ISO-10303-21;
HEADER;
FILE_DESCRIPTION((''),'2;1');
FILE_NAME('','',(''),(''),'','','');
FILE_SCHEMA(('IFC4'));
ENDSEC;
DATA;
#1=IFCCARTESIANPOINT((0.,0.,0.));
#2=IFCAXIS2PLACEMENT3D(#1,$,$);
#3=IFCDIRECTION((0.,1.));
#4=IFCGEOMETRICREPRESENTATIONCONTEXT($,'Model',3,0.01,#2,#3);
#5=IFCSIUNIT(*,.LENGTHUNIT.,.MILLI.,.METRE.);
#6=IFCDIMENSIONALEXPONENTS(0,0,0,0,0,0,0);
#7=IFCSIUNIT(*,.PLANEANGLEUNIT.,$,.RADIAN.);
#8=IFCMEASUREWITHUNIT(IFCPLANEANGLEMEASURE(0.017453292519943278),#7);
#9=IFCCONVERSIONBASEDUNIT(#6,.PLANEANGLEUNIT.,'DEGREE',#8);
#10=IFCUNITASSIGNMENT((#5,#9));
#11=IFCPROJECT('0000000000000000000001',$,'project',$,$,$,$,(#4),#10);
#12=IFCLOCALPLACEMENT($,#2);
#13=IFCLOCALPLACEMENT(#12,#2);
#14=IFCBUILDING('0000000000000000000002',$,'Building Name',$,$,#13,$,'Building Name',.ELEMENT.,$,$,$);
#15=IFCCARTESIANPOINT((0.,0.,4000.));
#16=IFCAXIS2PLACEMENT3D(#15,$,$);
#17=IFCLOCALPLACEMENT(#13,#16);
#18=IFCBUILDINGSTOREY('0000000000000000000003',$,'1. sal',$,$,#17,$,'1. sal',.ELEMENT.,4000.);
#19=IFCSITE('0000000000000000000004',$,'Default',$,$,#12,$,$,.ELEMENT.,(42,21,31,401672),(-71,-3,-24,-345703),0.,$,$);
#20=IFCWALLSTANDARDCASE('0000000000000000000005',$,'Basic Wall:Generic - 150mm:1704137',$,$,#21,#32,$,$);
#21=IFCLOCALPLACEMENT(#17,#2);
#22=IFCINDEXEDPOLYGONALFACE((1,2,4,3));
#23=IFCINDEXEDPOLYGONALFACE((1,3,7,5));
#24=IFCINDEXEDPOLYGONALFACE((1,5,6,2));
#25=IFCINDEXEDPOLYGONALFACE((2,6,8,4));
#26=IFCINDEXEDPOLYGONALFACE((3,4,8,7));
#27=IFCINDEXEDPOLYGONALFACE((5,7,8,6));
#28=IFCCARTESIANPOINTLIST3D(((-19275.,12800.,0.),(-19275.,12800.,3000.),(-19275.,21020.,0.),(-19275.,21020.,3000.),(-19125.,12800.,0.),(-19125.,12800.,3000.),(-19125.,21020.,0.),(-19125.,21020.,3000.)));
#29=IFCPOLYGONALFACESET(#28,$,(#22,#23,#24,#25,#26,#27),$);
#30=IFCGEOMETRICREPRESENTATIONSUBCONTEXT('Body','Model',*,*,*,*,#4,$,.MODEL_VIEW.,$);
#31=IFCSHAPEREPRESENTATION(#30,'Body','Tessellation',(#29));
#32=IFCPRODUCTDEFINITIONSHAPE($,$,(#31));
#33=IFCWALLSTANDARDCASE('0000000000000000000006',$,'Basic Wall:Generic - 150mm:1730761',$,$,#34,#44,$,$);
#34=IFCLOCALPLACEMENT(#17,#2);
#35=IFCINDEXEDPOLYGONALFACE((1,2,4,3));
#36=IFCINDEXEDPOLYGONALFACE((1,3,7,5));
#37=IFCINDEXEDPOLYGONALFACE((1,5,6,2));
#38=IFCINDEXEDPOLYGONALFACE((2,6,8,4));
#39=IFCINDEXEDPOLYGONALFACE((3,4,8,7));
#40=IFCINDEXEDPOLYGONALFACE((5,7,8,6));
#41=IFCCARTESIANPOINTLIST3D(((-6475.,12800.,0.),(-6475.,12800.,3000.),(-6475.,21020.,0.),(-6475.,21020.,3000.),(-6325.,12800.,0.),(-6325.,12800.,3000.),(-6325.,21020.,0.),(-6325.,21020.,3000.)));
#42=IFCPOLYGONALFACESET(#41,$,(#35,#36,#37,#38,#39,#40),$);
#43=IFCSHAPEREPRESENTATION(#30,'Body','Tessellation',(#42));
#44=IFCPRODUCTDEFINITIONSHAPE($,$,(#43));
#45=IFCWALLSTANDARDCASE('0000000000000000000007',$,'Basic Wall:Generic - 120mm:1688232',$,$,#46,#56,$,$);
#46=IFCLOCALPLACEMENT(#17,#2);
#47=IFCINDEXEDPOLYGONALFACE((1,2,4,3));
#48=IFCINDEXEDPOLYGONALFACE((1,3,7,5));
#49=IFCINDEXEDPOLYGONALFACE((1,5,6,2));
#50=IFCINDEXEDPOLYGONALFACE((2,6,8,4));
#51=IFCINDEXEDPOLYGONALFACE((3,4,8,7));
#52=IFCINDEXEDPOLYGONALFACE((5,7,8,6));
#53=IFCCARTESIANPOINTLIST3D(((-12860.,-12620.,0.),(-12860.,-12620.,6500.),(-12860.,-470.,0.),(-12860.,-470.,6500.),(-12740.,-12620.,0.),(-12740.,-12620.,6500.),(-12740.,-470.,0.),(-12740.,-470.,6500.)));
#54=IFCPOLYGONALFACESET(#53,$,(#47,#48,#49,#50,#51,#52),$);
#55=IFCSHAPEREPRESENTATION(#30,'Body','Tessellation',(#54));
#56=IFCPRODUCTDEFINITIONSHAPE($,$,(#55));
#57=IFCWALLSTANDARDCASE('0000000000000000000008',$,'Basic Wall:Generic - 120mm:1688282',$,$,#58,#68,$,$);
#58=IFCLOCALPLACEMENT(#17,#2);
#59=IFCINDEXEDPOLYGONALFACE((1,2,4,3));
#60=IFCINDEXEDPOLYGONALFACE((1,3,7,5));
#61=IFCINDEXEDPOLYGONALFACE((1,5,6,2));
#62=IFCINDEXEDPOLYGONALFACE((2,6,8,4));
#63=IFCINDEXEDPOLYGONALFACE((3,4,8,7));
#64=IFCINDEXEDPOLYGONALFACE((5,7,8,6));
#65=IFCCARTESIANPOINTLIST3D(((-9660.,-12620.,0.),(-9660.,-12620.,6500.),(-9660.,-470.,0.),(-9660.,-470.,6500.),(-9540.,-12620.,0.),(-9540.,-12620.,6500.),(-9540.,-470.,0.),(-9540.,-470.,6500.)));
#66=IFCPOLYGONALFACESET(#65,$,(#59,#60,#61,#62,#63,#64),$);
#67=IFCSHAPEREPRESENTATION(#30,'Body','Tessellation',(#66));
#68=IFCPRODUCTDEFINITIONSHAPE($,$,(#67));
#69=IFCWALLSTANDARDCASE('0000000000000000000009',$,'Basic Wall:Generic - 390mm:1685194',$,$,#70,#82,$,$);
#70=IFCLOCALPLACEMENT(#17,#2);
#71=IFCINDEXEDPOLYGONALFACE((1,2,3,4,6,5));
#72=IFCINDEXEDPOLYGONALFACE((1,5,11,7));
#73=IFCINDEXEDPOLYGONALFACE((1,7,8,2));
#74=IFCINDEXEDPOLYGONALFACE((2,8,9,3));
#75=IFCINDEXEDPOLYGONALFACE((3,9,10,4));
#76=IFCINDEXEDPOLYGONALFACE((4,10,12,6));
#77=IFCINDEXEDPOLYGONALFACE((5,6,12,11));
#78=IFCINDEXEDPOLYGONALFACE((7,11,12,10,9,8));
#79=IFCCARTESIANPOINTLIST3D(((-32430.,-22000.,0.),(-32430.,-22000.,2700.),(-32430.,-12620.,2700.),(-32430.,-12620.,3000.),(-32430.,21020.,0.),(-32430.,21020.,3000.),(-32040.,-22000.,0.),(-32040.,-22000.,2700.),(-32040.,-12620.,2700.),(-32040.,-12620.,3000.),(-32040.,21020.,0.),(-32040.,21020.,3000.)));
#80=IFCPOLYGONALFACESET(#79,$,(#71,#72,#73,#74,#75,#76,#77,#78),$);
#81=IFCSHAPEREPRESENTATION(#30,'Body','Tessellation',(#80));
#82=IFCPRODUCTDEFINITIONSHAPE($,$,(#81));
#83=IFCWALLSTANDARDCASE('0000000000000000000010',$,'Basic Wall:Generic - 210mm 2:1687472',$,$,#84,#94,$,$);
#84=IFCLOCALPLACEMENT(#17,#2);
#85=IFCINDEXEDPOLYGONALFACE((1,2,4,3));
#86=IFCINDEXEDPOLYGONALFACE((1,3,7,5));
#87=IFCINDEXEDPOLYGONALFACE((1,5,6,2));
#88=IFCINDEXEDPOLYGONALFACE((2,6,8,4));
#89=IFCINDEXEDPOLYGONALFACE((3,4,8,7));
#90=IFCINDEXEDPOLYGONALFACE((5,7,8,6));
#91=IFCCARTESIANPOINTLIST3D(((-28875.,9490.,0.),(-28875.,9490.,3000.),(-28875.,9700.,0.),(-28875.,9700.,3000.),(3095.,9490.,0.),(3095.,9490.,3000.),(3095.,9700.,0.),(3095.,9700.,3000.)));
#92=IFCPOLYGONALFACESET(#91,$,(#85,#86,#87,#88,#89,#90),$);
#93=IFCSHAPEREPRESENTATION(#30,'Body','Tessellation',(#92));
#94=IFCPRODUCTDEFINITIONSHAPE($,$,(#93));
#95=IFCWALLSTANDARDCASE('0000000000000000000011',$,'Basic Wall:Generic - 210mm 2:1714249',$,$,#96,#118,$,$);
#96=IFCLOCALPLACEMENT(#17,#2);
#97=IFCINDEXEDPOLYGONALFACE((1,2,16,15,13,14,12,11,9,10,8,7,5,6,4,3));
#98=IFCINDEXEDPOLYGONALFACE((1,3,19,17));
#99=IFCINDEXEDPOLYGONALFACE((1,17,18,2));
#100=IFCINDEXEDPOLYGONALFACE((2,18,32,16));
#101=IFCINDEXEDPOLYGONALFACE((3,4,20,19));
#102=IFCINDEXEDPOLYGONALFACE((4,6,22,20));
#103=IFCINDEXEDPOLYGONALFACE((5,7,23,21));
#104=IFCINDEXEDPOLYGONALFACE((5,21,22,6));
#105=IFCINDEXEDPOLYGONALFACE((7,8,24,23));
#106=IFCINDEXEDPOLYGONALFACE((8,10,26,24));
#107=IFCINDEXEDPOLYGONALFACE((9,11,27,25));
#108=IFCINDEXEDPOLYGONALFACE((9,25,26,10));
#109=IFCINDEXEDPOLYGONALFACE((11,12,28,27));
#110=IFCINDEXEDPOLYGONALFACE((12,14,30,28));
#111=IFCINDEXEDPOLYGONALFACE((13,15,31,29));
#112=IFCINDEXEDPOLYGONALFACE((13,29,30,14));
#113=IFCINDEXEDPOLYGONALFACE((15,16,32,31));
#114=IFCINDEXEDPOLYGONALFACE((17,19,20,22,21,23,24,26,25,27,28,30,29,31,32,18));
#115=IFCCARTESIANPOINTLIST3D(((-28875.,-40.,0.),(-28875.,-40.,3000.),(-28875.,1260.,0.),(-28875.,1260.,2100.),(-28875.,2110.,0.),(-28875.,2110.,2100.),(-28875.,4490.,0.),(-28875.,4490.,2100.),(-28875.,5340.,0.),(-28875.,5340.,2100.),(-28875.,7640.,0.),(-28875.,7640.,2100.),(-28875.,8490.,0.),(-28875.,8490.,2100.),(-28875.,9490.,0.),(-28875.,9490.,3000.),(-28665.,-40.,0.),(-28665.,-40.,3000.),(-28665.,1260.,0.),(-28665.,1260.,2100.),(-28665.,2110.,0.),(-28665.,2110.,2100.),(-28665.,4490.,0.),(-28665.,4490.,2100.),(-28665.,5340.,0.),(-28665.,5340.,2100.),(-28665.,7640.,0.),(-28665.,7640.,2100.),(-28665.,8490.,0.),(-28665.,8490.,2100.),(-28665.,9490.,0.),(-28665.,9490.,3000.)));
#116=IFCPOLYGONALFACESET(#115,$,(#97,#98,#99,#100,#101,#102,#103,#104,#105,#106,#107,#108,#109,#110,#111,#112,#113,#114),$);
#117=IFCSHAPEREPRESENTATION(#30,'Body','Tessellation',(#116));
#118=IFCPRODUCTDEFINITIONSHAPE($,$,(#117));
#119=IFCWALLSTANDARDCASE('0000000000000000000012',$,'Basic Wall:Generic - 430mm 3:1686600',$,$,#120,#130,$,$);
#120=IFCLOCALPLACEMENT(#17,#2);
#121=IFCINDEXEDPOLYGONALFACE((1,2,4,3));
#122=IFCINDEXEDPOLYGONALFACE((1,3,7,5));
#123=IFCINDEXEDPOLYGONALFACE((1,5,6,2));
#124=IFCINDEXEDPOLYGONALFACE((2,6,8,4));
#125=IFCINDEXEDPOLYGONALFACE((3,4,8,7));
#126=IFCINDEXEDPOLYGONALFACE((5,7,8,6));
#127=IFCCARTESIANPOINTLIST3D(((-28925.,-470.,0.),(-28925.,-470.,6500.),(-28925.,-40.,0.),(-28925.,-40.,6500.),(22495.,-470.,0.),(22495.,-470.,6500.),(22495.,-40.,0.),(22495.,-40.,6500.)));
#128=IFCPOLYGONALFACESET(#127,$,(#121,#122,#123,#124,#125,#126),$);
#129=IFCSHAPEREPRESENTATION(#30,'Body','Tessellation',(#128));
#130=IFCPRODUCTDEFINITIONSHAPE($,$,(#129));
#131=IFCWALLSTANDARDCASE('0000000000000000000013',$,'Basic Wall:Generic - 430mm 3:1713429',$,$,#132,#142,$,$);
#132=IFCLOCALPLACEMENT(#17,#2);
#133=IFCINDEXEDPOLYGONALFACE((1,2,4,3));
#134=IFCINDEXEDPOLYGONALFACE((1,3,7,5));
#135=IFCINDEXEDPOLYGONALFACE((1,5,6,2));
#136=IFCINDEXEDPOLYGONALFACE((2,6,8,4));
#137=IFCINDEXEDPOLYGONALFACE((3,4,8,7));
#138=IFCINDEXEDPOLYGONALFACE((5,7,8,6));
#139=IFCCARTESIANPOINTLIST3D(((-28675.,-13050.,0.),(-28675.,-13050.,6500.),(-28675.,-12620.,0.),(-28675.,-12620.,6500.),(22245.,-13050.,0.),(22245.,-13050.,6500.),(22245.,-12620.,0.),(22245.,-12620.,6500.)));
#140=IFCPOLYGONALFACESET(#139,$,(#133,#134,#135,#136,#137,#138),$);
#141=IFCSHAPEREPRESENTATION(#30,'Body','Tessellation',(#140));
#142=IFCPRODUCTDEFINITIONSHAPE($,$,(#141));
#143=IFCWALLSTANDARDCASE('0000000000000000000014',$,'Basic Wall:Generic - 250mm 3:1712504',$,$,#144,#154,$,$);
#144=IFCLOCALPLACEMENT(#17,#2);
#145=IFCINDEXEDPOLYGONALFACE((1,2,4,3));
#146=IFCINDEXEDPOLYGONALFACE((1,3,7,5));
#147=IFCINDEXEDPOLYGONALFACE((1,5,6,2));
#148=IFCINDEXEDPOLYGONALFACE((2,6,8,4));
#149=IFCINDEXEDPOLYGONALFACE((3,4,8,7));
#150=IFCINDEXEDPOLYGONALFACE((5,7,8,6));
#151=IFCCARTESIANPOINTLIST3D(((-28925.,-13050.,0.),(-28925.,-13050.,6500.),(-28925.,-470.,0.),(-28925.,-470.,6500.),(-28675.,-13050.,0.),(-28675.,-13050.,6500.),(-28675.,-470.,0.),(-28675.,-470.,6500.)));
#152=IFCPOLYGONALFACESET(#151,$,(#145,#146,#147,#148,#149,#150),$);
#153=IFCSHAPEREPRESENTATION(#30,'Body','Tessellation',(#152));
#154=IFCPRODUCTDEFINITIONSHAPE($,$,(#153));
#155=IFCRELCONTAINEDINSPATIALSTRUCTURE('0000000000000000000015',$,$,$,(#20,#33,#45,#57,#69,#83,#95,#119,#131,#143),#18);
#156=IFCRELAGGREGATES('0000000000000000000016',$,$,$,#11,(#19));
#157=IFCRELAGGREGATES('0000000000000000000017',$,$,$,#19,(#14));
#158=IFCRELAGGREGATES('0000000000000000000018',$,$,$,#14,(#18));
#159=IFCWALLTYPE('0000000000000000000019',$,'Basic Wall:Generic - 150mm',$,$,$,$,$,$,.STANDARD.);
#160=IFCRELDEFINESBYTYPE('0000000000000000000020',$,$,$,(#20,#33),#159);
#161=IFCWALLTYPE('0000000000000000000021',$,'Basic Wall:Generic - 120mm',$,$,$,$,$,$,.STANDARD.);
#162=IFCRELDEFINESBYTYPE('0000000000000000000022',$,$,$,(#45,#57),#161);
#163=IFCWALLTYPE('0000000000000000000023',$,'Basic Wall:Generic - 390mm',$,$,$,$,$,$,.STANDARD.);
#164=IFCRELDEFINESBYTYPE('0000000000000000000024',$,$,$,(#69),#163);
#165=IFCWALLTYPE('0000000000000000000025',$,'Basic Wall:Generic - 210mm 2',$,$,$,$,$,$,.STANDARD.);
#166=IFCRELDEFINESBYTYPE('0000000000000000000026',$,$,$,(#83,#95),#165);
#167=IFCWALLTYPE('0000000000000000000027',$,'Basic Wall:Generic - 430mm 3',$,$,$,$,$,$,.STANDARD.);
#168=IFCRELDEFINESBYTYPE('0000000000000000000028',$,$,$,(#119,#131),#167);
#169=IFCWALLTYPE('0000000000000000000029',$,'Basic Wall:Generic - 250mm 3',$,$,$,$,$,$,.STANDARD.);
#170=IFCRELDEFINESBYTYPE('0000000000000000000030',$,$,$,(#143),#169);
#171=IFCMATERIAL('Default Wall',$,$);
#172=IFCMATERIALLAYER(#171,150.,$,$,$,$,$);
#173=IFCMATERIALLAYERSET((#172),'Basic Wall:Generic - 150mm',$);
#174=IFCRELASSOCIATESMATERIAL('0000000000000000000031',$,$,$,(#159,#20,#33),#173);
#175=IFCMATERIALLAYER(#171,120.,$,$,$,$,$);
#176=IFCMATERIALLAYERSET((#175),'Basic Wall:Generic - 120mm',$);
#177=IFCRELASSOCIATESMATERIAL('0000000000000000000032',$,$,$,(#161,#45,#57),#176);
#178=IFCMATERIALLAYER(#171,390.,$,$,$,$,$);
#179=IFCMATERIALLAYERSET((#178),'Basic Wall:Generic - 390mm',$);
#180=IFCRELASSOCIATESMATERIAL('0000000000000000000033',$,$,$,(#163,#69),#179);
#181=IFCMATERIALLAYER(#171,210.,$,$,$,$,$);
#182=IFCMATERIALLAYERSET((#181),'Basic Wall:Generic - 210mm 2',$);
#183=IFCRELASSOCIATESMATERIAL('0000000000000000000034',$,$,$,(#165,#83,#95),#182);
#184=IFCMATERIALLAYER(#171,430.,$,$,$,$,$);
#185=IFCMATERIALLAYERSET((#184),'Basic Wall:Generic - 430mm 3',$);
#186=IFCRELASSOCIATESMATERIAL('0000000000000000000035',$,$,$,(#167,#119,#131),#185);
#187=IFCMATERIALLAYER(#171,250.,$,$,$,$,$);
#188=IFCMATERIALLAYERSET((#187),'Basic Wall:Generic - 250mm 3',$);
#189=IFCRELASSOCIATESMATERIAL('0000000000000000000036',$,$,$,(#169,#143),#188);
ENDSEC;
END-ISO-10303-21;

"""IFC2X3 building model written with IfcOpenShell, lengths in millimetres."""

from ifc_helpers import new_model, entity, si_unit, converted_unit, direction, frame, frame_2d, origin, place, context, subcontext, project, spatial, polyline, rectangle, extrude, clip, bounded_halfspace, material, layer, layer_set, layer_usage, type_object, element, save


model = new_model("IFC2X3")

# Units and contexts
model_context = context("Model", 3, precision=0.01, world=origin(), true_north=direction((0.0, 1.0)))
body_context = subcontext(model_context, "Body", "Model", "MODEL_VIEW")
ifc_project = project(units=[si_unit("LENGTHUNIT", "METRE", prefix="MILLI"), converted_unit("PLANEANGLEUNIT", "DEGREE", entity("IfcPlaneAngleMeasure", 0.017453292519943278), si_unit("PLANEANGLEUNIT", "RADIAN"), dimensions=[0, 0, 0, 0, 0, 0, 0])], contexts=[model_context])

# Site, building, storey
site_placement = place(None, origin())
site = spatial("IfcSite", under=ifc_project, at=site_placement, Name="Default", CompositionType="ELEMENT", RefLatitude=(42, 21, 31, 401672), RefLongitude=(-71, -3, -24, -345703), RefElevation=0.0)
building_placement = place(site_placement, origin())
building = spatial("IfcBuilding", under=site, at=building_placement, Name="Building Name", LongName="Building Name", CompositionType="ELEMENT")
storey_placement = place(building_placement, frame((0.0, 0.0, 4000.0)))
storey = spatial("IfcBuildingStorey", under=building, at=storey_placement, Name="1. sal", LongName="1. sal", CompositionType="ELEMENT", Elevation=4000.0)

# Walls
ifc_material_1 = material(Name="Default Wall")
ifc_layer_1 = layer(ifc_material_1, 150.0)
ifc_layer_set_1 = layer_set([ifc_layer_1], Name="Basic Wall:Generic - 150mm")
ifc_layer_usage_1 = layer_usage(ifc_layer_set_1, "AXIS2", "NEGATIVE", 75.0)
wall_type_1 = type_object("IfcWallType", Name="Basic Wall:Generic - 150mm", PredefinedType="STANDARD", material=ifc_layer_set_1)
wall_1_placement = place(storey_placement, frame((-19200.0, 21020.0, 0.0), z_axis=(0.0, 0.0, 1.0), x_axis=(0.0, -1.0, 0.0)))
element("IfcWallStandardCase", 1, at=wall_1_placement, inside=storey, type_object=wall_type_1, material=ifc_layer_usage_1, Name="Basic Wall:Generic - 150mm:1704137", context=body_context, shape_type="SweptSolid", body=[
    extrude(rectangle(XDim=8220.0, YDim=150.0, at=frame_2d((4110.0, 0.0), x_axis=(-1.0, 0.0))), origin(), (0.0, 0.0, 1.0), 3000.0),
])
ifc_layer_usage_2 = layer_usage(ifc_layer_set_1, "AXIS2", "NEGATIVE", 75.0)
wall_2_placement = place(storey_placement, frame((-6400.0, 21020.0, 0.0), z_axis=(0.0, 0.0, 1.0), x_axis=(0.0, -1.0, 0.0)))
element("IfcWallStandardCase", 2, at=wall_2_placement, inside=storey, type_object=wall_type_1, material=ifc_layer_usage_2, Name="Basic Wall:Generic - 150mm:1730761", context=body_context, shape_type="SweptSolid", body=[
    extrude(rectangle(XDim=8220.0, YDim=150.0, at=frame_2d((4110.0, 0.0), x_axis=(-1.0, 0.0))), origin(), (0.0, 0.0, 1.0), 3000.0),
])
ifc_layer_2 = layer(ifc_material_1, 120.0)
ifc_layer_set_2 = layer_set([ifc_layer_2], Name="Basic Wall:Generic - 120mm")
ifc_layer_usage_3 = layer_usage(ifc_layer_set_2, "AXIS2", "NEGATIVE", 60.0)
wall_type_2 = type_object("IfcWallType", Name="Basic Wall:Generic - 120mm", PredefinedType="STANDARD", material=ifc_layer_set_2)
wall_3_placement = place(storey_placement, frame((-12800.0, -470.0, 0.0), z_axis=(0.0, 0.0, 1.0), x_axis=(0.0, -1.0, 0.0)))
element("IfcWallStandardCase", 3, at=wall_3_placement, inside=storey, type_object=wall_type_2, material=ifc_layer_usage_3, Name="Basic Wall:Generic - 120mm:1688232", context=body_context, shape_type="SweptSolid", body=[
    extrude(rectangle(XDim=12150.0, YDim=120.0, at=frame_2d((6075.0, 0.0), x_axis=(-1.0, 0.0))), origin(), (0.0, 0.0, 1.0), 6500.0),
])
ifc_layer_usage_4 = layer_usage(ifc_layer_set_2, "AXIS2", "NEGATIVE", 60.0)
wall_4_placement = place(storey_placement, frame((-9600.0, -470.0, 0.0), z_axis=(0.0, 0.0, 1.0), x_axis=(0.0, -1.0, 0.0)))
element("IfcWallStandardCase", 4, at=wall_4_placement, inside=storey, type_object=wall_type_2, material=ifc_layer_usage_4, Name="Basic Wall:Generic - 120mm:1688282", context=body_context, shape_type="SweptSolid", body=[
    extrude(rectangle(XDim=12150.0, YDim=120.0, at=frame_2d((6075.0, 0.0), x_axis=(-1.0, 0.0))), origin(), (0.0, 0.0, 1.0), 6500.0),
])
ifc_layer_3 = layer(ifc_material_1, 390.0)
ifc_layer_set_3 = layer_set([ifc_layer_3], Name="Basic Wall:Generic - 390mm")
ifc_layer_usage_5 = layer_usage(ifc_layer_set_3, "AXIS2", "NEGATIVE", 195.0)
wall_type_3 = type_object("IfcWallType", Name="Basic Wall:Generic - 390mm", PredefinedType="STANDARD", material=ifc_layer_set_3)
wall_5_placement = place(storey_placement, frame((-32235.0, -22000.0, 0.0), z_axis=(0.0, 0.0, 1.0), x_axis=(0.0, 1.0, 0.0)))
element("IfcWallStandardCase", 5, at=wall_5_placement, inside=storey, type_object=wall_type_3, material=ifc_layer_usage_5, Name="Basic Wall:Generic - 390mm:1685194", context=body_context, shape_type="Clipping", body=[
    clip(extrude(rectangle(XDim=43020.0, YDim=390.0, at=frame_2d((21510.0, 0.0), x_axis=(-1.0, 0.0))), origin(), (0.0, 0.0, 1.0), 3000.0), bounded_halfspace(frame((0.0, -195.0, 2700.0), z_axis=(0.0, 0.0, -1.0), x_axis=(1.0, 0.0, 0.0)), True, frame((0.0, -195.0, 2700.0)), polyline([(0.0, 0.0), (2695.0, 0.0), (2905.0, 0.0), (9380.0, 0.0), (9380.0, 390.0), (0.0, 390.0), (0.0, 0.0)]))),
])
ifc_layer_4 = layer(ifc_material_1, 210.0)
ifc_layer_set_4 = layer_set([ifc_layer_4], Name="Basic Wall:Generic - 210mm 2")
ifc_layer_usage_6 = layer_usage(ifc_layer_set_4, "AXIS2", "NEGATIVE", 105.0)
wall_type_4 = type_object("IfcWallType", Name="Basic Wall:Generic - 210mm 2", PredefinedType="STANDARD", material=ifc_layer_set_4)
wall_6_placement = place(storey_placement, frame((-28875.0, 9595.0, 0.0)))
element("IfcWallStandardCase", 6, at=wall_6_placement, inside=storey, type_object=wall_type_4, material=ifc_layer_usage_6, Name="Basic Wall:Generic - 210mm 2:1687472", context=body_context, shape_type="SweptSolid", body=[
    extrude(rectangle(XDim=31970.0, YDim=210.0, at=frame_2d((15985.0, 0.0), x_axis=(-1.0, 0.0))), origin(), (0.0, 0.0, 1.0), 3000.0),
])

# Wall, openings
ifc_layer_usage_7 = layer_usage(ifc_layer_set_4, "AXIS2", "NEGATIVE", 105.0)
wall_7_placement = place(storey_placement, frame((-28770.0, -40.0, 0.0), z_axis=(0.0, 0.0, 1.0), x_axis=(0.0, 1.0, 0.0)))
wall_7 = element("IfcWallStandardCase", 7, at=wall_7_placement, inside=storey, type_object=wall_type_4, material=ifc_layer_usage_7, Name="Basic Wall:Generic - 210mm 2:1714249", context=body_context, shape_type="SweptSolid", body=[
    extrude(rectangle(XDim=9530.0, YDim=210.0, at=frame_2d((4765.0, 0.0), x_axis=(-1.0, 0.0))), origin(), (0.0, 0.0, 1.0), 3000.0),
])
opening_1_placement = place(wall_7_placement, frame((8530.0, 105.0, 0.0)))
element("IfcOpeningElement", 8, at=opening_1_placement, cuts=wall_7, ObjectType="Opening", context=body_context, shape_type="SweptSolid", body=[
    extrude(rectangle(XDim=2100.0, YDim=850.0, at=frame_2d((1050.0, 425.0), x_axis=(1.0, 0.0))), frame((0.0, 0.0, 0.0), z_axis=(0.0, -1.0, 0.0), x_axis=(0.0, 0.0, 1.0)), (0.0, 0.0, 1.0), 210.0),
])
opening_2_placement = place(wall_7_placement, frame((5380.0, 105.0, 0.0)))
element("IfcOpeningElement", 9, at=opening_2_placement, cuts=wall_7, ObjectType="Opening", context=body_context, shape_type="SweptSolid", body=[
    extrude(rectangle(XDim=2100.0, YDim=850.0, at=frame_2d((1050.0, 425.0), x_axis=(1.0, 0.0))), frame((0.0, 0.0, 0.0), z_axis=(0.0, -1.0, 0.0), x_axis=(0.0, 0.0, 1.0)), (0.0, 0.0, 1.0), 210.0),
])
opening_3_placement = place(wall_7_placement, frame((2150.0, 105.0, 0.0)))
element("IfcOpeningElement", 10, at=opening_3_placement, cuts=wall_7, ObjectType="Opening", context=body_context, shape_type="SweptSolid", body=[
    extrude(rectangle(XDim=2100.0, YDim=850.0, at=frame_2d((1050.0, 425.0), x_axis=(1.0, 0.0))), frame((0.0, 0.0, 0.0), z_axis=(0.0, -1.0, 0.0), x_axis=(0.0, 0.0, 1.0)), (0.0, 0.0, 1.0), 210.0),
])

# Walls
ifc_layer_5 = layer(ifc_material_1, 430.0)
ifc_layer_set_5 = layer_set([ifc_layer_5], Name="Basic Wall:Generic - 430mm 3")
ifc_layer_usage_8 = layer_usage(ifc_layer_set_5, "AXIS2", "NEGATIVE", 215.0)
wall_type_5 = type_object("IfcWallType", Name="Basic Wall:Generic - 430mm 3", PredefinedType="STANDARD", material=ifc_layer_set_5)
wall_8_placement = place(storey_placement, frame((-28925.0, -255.0, 0.0)))
element("IfcWallStandardCase", 11, at=wall_8_placement, inside=storey, type_object=wall_type_5, material=ifc_layer_usage_8, Name="Basic Wall:Generic - 430mm 3:1686600", context=body_context, shape_type="SweptSolid", body=[
    extrude(rectangle(XDim=51420.0, YDim=430.0, at=frame_2d((25710.0, 0.0), x_axis=(-1.0, 0.0))), origin(), (0.0, 0.0, 1.0), 6500.0),
])
ifc_layer_usage_9 = layer_usage(ifc_layer_set_5, "AXIS2", "NEGATIVE", 215.0)
wall_9_placement = place(storey_placement, frame((-28675.0, -12835.0, 0.0)))
element("IfcWallStandardCase", 12, at=wall_9_placement, inside=storey, type_object=wall_type_5, material=ifc_layer_usage_9, Name="Basic Wall:Generic - 430mm 3:1713429", context=body_context, shape_type="SweptSolid", body=[
    extrude(rectangle(XDim=50920.0, YDim=430.0, at=frame_2d((25460.0, 0.0), x_axis=(-1.0, 0.0))), origin(), (0.0, 0.0, 1.0), 6500.0),
])
ifc_layer_6 = layer(ifc_material_1, 250.0)
ifc_layer_set_6 = layer_set([ifc_layer_6], Name="Basic Wall:Generic - 250mm 3")
ifc_layer_usage_10 = layer_usage(ifc_layer_set_6, "AXIS2", "NEGATIVE", 125.0)
wall_type_6 = type_object("IfcWallType", Name="Basic Wall:Generic - 250mm 3", PredefinedType="STANDARD", material=ifc_layer_set_6)
wall_10_placement = place(storey_placement, frame((-28800.0, -470.0, 0.0), z_axis=(0.0, 0.0, 1.0), x_axis=(0.0, -1.0, 0.0)))
element("IfcWallStandardCase", 13, at=wall_10_placement, inside=storey, type_object=wall_type_6, material=ifc_layer_usage_10, Name="Basic Wall:Generic - 250mm 3:1712504", context=body_context, shape_type="SweptSolid", body=[
    extrude(rectangle(XDim=12580.0, YDim=250.0, at=frame_2d((6290.0, 0.0), x_axis=(-1.0, 0.0))), origin(), (0.0, 0.0, 1.0), 6500.0),
])

save(model, "model.ifc")
